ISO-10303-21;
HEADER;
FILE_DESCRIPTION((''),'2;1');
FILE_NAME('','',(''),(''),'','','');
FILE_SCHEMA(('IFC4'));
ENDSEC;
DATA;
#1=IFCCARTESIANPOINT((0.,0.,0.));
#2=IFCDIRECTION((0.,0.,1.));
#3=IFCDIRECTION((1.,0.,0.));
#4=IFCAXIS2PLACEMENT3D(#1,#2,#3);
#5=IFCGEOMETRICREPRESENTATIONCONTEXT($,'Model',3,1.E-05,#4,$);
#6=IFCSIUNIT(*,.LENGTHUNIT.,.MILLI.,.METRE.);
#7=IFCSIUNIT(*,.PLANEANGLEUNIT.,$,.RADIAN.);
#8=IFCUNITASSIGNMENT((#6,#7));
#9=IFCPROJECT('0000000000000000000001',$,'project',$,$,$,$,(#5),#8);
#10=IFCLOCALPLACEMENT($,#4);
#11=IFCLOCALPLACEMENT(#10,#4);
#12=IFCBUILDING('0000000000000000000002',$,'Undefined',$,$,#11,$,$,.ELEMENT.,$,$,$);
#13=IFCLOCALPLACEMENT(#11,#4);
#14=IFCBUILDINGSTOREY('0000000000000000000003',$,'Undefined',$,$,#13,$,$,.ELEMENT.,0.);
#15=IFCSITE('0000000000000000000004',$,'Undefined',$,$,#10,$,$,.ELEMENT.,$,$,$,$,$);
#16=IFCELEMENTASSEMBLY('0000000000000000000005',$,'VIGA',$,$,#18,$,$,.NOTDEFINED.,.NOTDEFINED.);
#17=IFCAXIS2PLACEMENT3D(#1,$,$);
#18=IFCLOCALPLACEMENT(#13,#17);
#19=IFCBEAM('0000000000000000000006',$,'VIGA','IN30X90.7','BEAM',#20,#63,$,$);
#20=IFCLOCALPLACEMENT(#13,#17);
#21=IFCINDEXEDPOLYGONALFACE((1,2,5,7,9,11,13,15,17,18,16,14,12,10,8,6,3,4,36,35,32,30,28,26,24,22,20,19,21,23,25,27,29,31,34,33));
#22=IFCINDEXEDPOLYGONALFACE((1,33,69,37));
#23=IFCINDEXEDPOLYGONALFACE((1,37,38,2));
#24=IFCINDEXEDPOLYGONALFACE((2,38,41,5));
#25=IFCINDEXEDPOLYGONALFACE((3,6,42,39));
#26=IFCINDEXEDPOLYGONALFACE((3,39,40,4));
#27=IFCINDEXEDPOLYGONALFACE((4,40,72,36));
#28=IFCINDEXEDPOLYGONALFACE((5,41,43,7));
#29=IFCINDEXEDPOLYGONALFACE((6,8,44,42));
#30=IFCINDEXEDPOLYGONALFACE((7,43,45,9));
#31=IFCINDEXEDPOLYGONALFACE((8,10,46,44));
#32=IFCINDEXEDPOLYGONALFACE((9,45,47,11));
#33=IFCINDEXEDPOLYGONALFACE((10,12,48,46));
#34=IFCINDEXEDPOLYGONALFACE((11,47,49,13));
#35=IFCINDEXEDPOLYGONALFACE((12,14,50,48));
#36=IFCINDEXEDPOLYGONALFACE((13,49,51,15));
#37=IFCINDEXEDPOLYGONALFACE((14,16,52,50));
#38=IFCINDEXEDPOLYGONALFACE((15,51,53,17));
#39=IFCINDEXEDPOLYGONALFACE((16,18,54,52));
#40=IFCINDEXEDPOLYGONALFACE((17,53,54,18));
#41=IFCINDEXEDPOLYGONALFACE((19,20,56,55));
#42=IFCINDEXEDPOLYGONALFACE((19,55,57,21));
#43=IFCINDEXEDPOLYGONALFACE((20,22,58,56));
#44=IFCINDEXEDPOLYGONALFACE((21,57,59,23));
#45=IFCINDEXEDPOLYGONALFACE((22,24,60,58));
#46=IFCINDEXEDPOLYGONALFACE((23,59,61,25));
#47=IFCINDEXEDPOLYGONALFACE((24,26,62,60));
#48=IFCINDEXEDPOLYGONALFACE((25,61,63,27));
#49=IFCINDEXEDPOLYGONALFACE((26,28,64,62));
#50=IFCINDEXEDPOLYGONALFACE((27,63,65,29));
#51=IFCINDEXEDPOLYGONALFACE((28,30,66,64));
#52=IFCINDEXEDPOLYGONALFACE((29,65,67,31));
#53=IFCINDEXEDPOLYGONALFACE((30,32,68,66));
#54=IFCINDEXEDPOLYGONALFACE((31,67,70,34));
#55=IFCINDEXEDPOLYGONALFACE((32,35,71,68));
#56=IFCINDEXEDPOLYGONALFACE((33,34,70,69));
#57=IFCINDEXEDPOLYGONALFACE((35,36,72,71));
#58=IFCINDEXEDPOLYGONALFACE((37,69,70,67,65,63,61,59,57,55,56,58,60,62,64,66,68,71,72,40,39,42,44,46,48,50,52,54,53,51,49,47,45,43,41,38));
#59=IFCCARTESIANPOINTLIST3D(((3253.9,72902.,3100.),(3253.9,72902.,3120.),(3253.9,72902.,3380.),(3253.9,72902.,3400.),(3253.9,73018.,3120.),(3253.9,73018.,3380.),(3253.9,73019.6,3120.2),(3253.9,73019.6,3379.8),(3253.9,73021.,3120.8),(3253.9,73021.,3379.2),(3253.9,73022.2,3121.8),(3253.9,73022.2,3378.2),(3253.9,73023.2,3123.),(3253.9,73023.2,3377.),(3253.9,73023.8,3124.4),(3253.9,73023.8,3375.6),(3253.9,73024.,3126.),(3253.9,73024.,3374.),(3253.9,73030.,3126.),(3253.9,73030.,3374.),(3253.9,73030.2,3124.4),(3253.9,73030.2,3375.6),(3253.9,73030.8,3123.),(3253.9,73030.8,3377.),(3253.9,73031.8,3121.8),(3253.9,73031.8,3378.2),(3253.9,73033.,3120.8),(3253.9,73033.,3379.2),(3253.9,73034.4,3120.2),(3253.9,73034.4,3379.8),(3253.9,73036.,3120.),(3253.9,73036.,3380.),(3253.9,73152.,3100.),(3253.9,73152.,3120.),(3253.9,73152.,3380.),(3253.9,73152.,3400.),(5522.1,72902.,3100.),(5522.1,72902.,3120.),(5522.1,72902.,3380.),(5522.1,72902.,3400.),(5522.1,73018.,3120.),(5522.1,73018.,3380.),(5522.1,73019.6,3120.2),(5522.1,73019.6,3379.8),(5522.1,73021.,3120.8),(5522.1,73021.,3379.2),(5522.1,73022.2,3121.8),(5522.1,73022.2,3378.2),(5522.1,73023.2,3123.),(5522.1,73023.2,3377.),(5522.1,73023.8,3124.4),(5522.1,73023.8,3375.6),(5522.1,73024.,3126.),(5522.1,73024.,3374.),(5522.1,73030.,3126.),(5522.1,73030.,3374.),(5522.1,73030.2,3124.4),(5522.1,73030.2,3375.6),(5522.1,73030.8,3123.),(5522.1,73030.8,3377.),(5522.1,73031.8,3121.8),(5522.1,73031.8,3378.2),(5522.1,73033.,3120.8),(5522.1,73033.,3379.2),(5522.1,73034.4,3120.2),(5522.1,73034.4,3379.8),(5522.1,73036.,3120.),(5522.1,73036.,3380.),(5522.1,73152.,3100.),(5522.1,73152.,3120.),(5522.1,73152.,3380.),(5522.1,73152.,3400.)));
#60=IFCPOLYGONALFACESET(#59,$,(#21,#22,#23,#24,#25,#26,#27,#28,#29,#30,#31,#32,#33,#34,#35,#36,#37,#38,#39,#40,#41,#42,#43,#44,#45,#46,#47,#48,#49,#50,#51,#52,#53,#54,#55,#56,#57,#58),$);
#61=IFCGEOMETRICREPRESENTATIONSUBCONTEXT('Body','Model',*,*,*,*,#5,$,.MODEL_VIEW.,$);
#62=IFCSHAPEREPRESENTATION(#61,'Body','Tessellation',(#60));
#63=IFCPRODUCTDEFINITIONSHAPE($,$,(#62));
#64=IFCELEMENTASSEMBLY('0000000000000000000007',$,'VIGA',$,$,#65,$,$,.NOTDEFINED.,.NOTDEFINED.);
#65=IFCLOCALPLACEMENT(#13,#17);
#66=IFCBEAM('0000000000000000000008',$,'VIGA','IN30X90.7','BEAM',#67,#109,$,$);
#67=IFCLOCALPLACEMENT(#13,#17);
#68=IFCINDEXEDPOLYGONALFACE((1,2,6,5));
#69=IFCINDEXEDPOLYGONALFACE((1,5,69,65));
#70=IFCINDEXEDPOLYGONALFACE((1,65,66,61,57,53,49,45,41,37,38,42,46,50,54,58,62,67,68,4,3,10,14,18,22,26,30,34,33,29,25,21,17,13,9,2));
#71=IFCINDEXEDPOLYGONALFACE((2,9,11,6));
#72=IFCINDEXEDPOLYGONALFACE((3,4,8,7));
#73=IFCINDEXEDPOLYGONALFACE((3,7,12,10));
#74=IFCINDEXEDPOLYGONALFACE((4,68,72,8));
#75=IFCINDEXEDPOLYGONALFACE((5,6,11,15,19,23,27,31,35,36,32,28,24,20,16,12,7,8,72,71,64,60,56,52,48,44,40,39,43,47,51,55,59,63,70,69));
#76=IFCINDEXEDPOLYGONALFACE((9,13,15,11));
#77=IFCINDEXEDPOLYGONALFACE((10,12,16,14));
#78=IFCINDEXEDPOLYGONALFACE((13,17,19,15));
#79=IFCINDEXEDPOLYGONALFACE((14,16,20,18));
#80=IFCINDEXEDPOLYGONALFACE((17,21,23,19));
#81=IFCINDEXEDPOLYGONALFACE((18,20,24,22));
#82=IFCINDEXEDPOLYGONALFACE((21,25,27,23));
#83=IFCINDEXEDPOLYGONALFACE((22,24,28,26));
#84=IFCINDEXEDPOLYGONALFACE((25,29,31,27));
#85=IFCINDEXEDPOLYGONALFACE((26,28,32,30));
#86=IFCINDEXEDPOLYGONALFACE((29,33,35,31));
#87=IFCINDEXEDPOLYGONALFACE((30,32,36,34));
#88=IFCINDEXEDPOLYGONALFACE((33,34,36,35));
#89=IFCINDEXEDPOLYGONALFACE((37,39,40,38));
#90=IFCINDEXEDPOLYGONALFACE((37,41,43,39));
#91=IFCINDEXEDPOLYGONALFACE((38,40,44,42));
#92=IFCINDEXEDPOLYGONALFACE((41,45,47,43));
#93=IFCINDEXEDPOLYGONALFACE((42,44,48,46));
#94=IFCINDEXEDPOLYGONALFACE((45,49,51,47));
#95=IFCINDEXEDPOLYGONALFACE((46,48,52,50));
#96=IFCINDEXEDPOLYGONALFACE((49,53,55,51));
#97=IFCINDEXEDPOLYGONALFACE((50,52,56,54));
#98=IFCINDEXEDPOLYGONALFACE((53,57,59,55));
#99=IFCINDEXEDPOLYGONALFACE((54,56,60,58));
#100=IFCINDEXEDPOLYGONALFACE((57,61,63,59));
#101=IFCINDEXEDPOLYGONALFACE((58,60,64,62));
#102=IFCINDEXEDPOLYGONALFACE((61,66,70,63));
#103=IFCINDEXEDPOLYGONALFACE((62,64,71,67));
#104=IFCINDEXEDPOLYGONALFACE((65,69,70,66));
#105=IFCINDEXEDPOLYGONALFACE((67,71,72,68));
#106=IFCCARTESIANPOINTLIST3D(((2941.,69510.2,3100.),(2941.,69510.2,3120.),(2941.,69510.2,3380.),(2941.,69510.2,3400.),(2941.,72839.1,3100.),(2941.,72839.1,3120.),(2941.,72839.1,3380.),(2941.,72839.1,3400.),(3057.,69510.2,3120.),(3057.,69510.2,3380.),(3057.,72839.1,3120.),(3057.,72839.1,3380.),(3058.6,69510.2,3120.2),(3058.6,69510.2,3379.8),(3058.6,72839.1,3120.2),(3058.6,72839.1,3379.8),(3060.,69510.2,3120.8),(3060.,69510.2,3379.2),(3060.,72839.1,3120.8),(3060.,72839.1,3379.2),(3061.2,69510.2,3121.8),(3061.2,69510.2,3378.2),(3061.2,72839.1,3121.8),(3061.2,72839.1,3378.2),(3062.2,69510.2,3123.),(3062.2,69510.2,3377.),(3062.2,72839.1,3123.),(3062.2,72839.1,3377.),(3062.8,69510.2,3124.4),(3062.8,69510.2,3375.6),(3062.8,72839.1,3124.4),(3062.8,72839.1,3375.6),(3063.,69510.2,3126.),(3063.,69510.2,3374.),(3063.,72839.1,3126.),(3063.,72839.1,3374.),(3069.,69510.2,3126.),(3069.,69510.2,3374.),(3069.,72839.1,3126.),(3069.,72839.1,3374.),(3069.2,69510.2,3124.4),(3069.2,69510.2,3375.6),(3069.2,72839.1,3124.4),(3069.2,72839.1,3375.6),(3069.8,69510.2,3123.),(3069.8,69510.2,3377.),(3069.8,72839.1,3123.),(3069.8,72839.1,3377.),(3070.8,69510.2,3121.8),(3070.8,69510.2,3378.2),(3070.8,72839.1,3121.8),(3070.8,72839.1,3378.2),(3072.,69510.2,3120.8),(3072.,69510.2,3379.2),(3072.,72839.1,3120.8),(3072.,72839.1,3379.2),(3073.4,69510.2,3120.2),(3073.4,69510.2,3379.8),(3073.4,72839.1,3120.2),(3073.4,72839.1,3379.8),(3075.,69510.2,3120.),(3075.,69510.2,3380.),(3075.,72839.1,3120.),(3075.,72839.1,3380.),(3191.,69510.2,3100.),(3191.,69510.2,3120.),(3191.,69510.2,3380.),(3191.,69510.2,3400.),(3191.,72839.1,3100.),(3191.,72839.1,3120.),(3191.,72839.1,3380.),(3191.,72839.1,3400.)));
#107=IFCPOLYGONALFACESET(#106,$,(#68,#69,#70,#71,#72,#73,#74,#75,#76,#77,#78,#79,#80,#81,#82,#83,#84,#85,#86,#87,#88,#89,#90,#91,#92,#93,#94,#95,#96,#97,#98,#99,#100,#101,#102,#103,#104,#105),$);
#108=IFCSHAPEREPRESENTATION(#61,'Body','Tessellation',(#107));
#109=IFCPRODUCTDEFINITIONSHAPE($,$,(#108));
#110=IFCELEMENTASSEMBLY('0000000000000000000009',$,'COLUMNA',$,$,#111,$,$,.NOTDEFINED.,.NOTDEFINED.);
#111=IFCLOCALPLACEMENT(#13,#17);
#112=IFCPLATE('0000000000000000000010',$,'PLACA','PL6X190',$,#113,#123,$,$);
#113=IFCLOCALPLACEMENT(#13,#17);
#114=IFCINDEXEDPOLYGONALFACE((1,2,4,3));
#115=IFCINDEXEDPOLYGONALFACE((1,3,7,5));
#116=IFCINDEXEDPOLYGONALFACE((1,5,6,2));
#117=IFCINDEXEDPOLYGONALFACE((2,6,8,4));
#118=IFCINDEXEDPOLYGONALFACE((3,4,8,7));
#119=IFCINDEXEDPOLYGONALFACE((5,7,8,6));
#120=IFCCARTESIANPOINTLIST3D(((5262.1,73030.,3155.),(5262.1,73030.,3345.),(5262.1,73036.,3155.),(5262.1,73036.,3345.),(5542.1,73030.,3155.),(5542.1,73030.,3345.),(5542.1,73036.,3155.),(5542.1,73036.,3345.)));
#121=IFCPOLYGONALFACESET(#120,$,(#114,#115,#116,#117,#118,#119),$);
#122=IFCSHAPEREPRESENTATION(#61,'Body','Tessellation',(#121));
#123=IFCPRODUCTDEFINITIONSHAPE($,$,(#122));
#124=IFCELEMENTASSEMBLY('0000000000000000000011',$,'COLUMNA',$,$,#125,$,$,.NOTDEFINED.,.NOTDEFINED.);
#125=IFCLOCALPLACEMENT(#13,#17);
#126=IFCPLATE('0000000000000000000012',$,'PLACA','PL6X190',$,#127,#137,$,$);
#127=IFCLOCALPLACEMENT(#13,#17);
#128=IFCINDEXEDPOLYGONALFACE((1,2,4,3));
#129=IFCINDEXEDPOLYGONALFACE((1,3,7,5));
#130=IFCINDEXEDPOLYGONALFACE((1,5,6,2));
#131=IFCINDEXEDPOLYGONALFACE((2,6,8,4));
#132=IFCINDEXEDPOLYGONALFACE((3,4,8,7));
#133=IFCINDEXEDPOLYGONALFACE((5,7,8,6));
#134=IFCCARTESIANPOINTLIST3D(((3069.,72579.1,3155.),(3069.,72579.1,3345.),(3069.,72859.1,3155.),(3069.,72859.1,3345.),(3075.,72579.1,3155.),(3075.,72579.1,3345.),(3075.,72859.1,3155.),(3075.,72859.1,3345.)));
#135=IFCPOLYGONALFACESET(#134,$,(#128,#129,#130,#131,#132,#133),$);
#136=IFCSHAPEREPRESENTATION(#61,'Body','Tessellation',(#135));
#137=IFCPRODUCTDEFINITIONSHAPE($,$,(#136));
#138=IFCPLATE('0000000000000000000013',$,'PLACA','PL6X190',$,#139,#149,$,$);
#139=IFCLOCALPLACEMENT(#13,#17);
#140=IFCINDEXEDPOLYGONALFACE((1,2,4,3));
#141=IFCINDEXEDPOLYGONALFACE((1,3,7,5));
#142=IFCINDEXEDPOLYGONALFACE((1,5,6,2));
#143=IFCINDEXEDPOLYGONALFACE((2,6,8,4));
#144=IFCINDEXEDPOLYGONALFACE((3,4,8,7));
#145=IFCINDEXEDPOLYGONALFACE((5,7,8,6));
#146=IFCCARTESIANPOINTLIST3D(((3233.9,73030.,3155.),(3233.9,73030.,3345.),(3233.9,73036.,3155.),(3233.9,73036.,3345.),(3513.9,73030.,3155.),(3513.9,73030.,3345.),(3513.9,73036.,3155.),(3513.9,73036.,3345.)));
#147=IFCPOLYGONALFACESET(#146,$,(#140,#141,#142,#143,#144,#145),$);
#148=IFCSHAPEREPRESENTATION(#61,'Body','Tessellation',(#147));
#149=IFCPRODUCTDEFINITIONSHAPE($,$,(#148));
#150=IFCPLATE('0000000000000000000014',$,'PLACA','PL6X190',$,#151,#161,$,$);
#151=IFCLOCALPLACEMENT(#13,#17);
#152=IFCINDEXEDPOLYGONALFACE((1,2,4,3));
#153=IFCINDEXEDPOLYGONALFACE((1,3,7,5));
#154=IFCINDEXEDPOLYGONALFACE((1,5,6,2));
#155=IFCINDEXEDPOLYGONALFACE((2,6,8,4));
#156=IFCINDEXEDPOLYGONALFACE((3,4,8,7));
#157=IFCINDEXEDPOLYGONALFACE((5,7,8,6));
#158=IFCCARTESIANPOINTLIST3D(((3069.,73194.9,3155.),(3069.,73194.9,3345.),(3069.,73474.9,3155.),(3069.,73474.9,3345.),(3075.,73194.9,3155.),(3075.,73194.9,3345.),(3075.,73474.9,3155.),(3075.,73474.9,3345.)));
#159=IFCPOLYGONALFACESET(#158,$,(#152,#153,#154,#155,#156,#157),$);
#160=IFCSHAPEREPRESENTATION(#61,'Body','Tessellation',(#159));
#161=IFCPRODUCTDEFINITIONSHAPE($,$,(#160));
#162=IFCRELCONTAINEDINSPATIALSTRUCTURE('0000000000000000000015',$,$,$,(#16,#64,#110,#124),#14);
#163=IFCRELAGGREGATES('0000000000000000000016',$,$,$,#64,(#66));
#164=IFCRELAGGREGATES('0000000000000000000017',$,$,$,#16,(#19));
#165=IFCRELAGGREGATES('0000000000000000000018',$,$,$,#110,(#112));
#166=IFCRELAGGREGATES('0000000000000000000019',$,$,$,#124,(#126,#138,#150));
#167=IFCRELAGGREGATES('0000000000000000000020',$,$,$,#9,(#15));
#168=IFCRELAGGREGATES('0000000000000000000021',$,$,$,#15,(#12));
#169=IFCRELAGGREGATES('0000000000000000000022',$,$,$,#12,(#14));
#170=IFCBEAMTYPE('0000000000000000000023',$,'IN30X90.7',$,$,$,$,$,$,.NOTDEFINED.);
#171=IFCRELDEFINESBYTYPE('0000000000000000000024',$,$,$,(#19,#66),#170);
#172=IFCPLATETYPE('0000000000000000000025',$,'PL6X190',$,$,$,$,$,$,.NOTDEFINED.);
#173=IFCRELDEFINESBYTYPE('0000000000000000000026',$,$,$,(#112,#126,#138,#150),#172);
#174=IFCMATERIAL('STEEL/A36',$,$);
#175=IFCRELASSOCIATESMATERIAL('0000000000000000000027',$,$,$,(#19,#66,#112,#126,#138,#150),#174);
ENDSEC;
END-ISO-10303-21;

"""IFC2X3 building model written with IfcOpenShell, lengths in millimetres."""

from ifc_helpers import new_model, si_unit, frame, origin_with_axes, origin_2d_with_axis, place, context, subcontext, project, spatial, polyline, i_section, outline, extrude, material, type_object, element, aggregate, save


model = new_model("IFC2X3")

# Units and contexts
model_context = context("Model", 3, precision=1e-05, world=origin_with_axes())
body_context = subcontext(model_context, "Body", "Model", "MODEL_VIEW")
ifc_project = project(units=[si_unit("LENGTHUNIT", "METRE", prefix="MILLI"), si_unit("PLANEANGLEUNIT", "RADIAN")], contexts=[model_context])

# Site, building, storey
site_placement = place(None, origin_with_axes())
site = spatial("IfcSite", under=ifc_project, at=site_placement, Name="Undefined", CompositionType="ELEMENT")
building_placement = place(site_placement, origin_with_axes())
building = spatial("IfcBuilding", under=site, at=building_placement, Name="Undefined", CompositionType="ELEMENT")
storey_placement = place(building_placement, origin_with_axes())
storey = spatial("IfcBuildingStorey", under=building, at=storey_placement, Name="Undefined", CompositionType="ELEMENT", Elevation=0.0)

# Element assemblies, beams
assembly_1_placement = place(storey_placement, origin_with_axes())
assembly_1 = element("IfcElementAssembly", 1, at=assembly_1_placement, inside=storey, Name="VIGA", AssemblyPlace="NOTDEFINED", PredefinedType="NOTDEFINED")
ifc_material_1 = material(Name="STEEL/A36")
beam_type_1 = type_object("IfcBeamType", Name="IN30X90.7", PredefinedType="NOTDEFINED")
beam_1_placement = place(assembly_1_placement, frame((3253.9, 73027.0, 3250.0), z_axis=(0.0, 0.0, 1.0), x_axis=(1.0, 0.0, 0.0)))
beam_1 = element("IfcBeam", 2, at=beam_1_placement, type_object=beam_type_1, material=ifc_material_1, Name="VIGA", Description="IN30X90.7", ObjectType="BEAM", context=body_context, shape_type="SweptSolid", body=[
    extrude(i_section(OverallWidth=250.0, OverallDepth=300.0, WebThickness=6.0, FlangeThickness=20.0, FilletRadius=6.0, at=origin_2d_with_axis()), frame((2268.2, 0.0, 0.0), z_axis=(-1.0, 0.0, 0.0), x_axis=(0.0, -1.0, 0.0)), (0.0, 0.0, 1.0), 2268.2),
])
assembly_2_placement = place(storey_placement, origin_with_axes())
assembly_2 = element("IfcElementAssembly", 3, at=assembly_2_placement, inside=storey, Name="VIGA", AssemblyPlace="NOTDEFINED", PredefinedType="NOTDEFINED")
beam_2_placement = place(assembly_2_placement, frame((3066.0, 72839.1, 3250.0), z_axis=(0.0, 0.0, 1.0), x_axis=(0.0, -1.0, 0.0)))
beam_2 = element("IfcBeam", 4, at=beam_2_placement, type_object=beam_type_1, material=ifc_material_1, Name="VIGA", Description="IN30X90.7", ObjectType="BEAM", context=body_context, shape_type="SweptSolid", body=[
    extrude(i_section(OverallWidth=250.0, OverallDepth=300.0, WebThickness=6.0, FlangeThickness=20.0, FilletRadius=6.0, at=origin_2d_with_axis()), frame((3328.9, 0.0, 0.0), z_axis=(-1.0, 0.0, 0.0), x_axis=(0.0, -1.0, 0.0)), (0.0, 0.0, 1.0), 3328.9),
])
aggregate(assembly_2, [beam_2])

aggregate(assembly_1, [beam_1])

# Element assembly, plate
assembly_3_placement = place(storey_placement, origin_with_axes())
assembly_3 = element("IfcElementAssembly", 5, at=assembly_3_placement, inside=storey, Name="COLUMNA", AssemblyPlace="NOTDEFINED", PredefinedType="NOTDEFINED")
plate_type_1 = type_object("IfcPlateType", Name="PL6X190", PredefinedType="NOTDEFINED")
plate_1_placement = place(assembly_3_placement, frame((5262.1, 73033.0, 3250.0), z_axis=(0.0, -1.0, 0.0), x_axis=(1.0, 0.0, 0.0)))
plate_1 = element("IfcPlate", 6, at=plate_1_placement, type_object=plate_type_1, material=ifc_material_1, Name="PLACA", Description="PL6X190", context=body_context, shape_type="SweptSolid", body=[
    extrude(outline(polyline([(0.0, -95.0), (0.0, 95.0), (280.0, 95.0), (280.0, -95.0), (0.0, -95.0)])), frame((0.0, 0.0, -3.0), z_axis=(0.0, 0.0, 1.0), x_axis=(1.0, 0.0, 0.0)), (0.0, 0.0, 1.0), 6.0),
])

# Element assembly, plates
assembly_4_placement = place(storey_placement, origin_with_axes())
assembly_4 = element("IfcElementAssembly", 7, at=assembly_4_placement, inside=storey, Name="COLUMNA", AssemblyPlace="NOTDEFINED", PredefinedType="NOTDEFINED")
plate_2_placement = place(assembly_4_placement, frame((3072.0, 72579.1, 3250.0), z_axis=(1.0, 0.0, 0.0), x_axis=(0.0, 1.0, 0.0)))
plate_2 = element("IfcPlate", 8, at=plate_2_placement, type_object=plate_type_1, material=ifc_material_1, Name="PLACA", Description="PL6X190", context=body_context, shape_type="SweptSolid", body=[
    extrude(outline(polyline([(0.0, -95.0), (0.0, 95.0), (280.0, 95.0), (280.0, -95.0), (0.0, -95.0)])), frame((0.0, 0.0, -3.0), z_axis=(0.0, 0.0, 1.0), x_axis=(1.0, 0.0, 0.0)), (0.0, 0.0, 1.0), 6.0),
])
plate_3_placement = place(assembly_4_placement, frame((3513.9, 73033.0, 3250.0), z_axis=(0.0, 1.0, 0.0), x_axis=(-1.0, 0.0, 0.0)))
plate_3 = element("IfcPlate", 9, at=plate_3_placement, type_object=plate_type_1, material=ifc_material_1, Name="PLACA", Description="PL6X190", context=body_context, shape_type="SweptSolid", body=[
    extrude(outline(polyline([(0.0, -95.0), (0.0, 95.0), (280.0, 95.0), (280.0, -95.0), (0.0, -95.0)])), frame((0.0, 0.0, -3.0), z_axis=(0.0, 0.0, 1.0), x_axis=(1.0, 0.0, 0.0)), (0.0, 0.0, 1.0), 6.0),
])
plate_4_placement = place(assembly_4_placement, frame((3072.0, 73474.9, 3250.0), z_axis=(-1.0, 0.0, 0.0), x_axis=(0.0, -1.0, 0.0)))
plate_4 = element("IfcPlate", 10, at=plate_4_placement, type_object=plate_type_1, material=ifc_material_1, Name="PLACA", Description="PL6X190", context=body_context, shape_type="SweptSolid", body=[
    extrude(outline(polyline([(0.0, -95.0), (0.0, 95.0), (280.0, 95.0), (280.0, -95.0), (0.0, -95.0)])), frame((0.0, 0.0, -3.0), z_axis=(0.0, 0.0, 1.0), x_axis=(1.0, 0.0, 0.0)), (0.0, 0.0, 1.0), 6.0),
])

aggregate(assembly_3, [plate_1])
aggregate(assembly_4, [plate_2, plate_3, plate_4])

save(model, "model.ifc")
